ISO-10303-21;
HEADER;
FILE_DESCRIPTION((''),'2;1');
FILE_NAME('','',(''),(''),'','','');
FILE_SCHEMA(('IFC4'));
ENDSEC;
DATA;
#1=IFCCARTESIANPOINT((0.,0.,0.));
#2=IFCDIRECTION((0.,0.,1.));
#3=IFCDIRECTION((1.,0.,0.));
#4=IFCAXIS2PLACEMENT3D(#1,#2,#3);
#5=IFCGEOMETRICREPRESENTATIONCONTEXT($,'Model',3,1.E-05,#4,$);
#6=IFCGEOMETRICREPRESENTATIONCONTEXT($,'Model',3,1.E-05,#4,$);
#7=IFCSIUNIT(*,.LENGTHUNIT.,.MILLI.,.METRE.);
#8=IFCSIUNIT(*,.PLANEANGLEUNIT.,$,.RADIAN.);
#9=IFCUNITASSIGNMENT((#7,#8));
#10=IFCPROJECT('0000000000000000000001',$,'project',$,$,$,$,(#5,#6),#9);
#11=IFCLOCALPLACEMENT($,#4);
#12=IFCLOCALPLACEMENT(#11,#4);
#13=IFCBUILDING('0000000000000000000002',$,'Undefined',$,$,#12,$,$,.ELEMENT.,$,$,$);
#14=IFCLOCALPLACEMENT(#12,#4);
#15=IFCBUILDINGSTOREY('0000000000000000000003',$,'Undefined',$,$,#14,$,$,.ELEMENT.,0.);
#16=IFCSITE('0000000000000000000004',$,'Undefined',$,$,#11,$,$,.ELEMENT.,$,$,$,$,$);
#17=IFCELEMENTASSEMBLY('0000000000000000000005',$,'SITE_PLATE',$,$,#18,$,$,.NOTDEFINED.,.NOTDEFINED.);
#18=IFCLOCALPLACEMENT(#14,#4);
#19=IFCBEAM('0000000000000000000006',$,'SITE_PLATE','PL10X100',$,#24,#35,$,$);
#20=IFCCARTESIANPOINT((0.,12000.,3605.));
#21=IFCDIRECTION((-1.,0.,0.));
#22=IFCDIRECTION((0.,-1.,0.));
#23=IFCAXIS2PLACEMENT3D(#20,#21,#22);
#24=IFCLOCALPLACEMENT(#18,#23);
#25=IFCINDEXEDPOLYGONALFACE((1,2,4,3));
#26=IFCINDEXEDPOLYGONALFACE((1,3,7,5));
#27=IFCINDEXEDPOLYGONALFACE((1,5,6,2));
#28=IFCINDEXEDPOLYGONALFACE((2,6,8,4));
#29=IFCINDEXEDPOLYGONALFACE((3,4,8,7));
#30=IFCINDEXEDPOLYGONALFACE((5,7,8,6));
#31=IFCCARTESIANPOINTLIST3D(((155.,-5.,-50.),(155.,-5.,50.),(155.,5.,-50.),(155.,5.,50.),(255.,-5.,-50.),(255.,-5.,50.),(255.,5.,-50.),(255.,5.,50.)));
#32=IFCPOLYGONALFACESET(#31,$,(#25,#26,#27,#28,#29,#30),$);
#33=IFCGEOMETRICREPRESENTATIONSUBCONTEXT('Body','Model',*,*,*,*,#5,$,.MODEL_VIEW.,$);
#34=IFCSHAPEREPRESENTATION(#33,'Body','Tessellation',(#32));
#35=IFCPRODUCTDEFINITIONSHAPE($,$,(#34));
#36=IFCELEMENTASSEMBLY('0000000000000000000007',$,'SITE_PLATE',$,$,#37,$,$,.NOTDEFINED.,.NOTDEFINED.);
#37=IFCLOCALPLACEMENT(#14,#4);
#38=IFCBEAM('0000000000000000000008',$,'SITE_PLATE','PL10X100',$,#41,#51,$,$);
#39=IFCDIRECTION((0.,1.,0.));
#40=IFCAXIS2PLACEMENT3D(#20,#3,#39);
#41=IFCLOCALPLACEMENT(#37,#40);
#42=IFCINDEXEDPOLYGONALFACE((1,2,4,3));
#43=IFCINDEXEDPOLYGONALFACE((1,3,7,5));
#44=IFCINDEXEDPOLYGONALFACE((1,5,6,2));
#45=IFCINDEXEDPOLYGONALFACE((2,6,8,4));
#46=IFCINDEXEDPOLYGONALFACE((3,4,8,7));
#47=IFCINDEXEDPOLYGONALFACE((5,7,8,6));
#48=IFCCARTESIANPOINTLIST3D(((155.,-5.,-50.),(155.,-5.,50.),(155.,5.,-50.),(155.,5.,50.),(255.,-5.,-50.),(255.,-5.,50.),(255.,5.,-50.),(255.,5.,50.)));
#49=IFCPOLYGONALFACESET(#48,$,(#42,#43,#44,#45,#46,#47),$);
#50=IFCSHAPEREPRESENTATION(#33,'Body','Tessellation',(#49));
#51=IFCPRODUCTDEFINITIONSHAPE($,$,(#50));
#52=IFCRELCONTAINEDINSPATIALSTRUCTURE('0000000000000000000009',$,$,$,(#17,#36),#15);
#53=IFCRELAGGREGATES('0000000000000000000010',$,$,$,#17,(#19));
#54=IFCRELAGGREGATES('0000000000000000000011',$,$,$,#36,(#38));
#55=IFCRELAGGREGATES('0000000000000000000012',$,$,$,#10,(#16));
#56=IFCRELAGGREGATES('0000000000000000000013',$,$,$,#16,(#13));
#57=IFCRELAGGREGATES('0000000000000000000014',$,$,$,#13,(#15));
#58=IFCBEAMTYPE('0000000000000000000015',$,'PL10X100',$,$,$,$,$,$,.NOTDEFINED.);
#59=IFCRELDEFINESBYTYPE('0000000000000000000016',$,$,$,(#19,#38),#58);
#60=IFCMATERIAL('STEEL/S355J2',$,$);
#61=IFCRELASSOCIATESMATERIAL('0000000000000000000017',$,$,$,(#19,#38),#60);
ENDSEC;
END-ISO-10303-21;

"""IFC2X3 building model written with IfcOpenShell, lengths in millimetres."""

from ifc_helpers import new_model, si_unit, frame, origin_with_axes, origin_2d_with_axis, place, context, subcontext, project, spatial, rectangle, extrude, clip, halfspace, material, type_object, element, aggregate, save


model = new_model("IFC2X3")

# Units and contexts
model_context_1 = context("Model", 3, precision=1e-05, world=origin_with_axes())
model_context_2 = context("Model", 3, precision=1e-05, world=origin_with_axes())
body_context = subcontext(model_context_1, "Body", "Model", "MODEL_VIEW")
ifc_project = project(units=[si_unit("LENGTHUNIT", "METRE", prefix="MILLI"), si_unit("PLANEANGLEUNIT", "RADIAN")], contexts=[model_context_1, model_context_2])

# Site, building, storey
site_placement = place(None, origin_with_axes())
site = spatial("IfcSite", under=ifc_project, at=site_placement, Name="Undefined", CompositionType="ELEMENT")
building_placement = place(site_placement, origin_with_axes())
building = spatial("IfcBuilding", under=site, at=building_placement, Name="Undefined", CompositionType="ELEMENT")
storey_placement = place(building_placement, origin_with_axes())
storey = spatial("IfcBuildingStorey", under=building, at=storey_placement, Name="Undefined", CompositionType="ELEMENT", Elevation=0.0)

# Element assemblies, beams
ifc_material_1 = material(Name="STEEL/S355J2")
assembly_1_placement = place(storey_placement, origin_with_axes())
assembly_1 = element("IfcElementAssembly", 1, at=assembly_1_placement, inside=storey, Name="SITE_PLATE", AssemblyPlace="NOTDEFINED", PredefinedType="NOTDEFINED")
beam_type_1 = type_object("IfcBeamType", Name="PL10X100", PredefinedType="NOTDEFINED")
beam_1_placement = place(assembly_1_placement, frame((0.0, 12000.0, 3605.0), z_axis=(-1.0, 0.0, 0.0), x_axis=(0.0, -1.0, 0.0)))
beam_1 = element("IfcBeam", 2, at=beam_1_placement, type_object=beam_type_1, material=ifc_material_1, Name="SITE_PLATE", Description="PL10X100", context=body_context, shape_type="Clipping", body=[
    clip(extrude(rectangle(XDim=10.0, YDim=100.0, at=origin_2d_with_axis()), frame((255.0, 0.0, 0.0), z_axis=(-1.0, 0.0, 0.0), x_axis=(0.0, -1.0, 0.0)), (0.0, 0.0, 1.0), 255.0), halfspace(frame((155.0, 5.0, -50.0), z_axis=(-1.0, 0.0, 0.0), x_axis=(0.0, 0.0, 1.0)), False)),
])
aggregate(assembly_1, [beam_1])
assembly_2_placement = place(storey_placement, origin_with_axes())
assembly_2 = element("IfcElementAssembly", 3, at=assembly_2_placement, inside=storey, Name="SITE_PLATE", AssemblyPlace="NOTDEFINED", PredefinedType="NOTDEFINED")
beam_2_placement = place(assembly_2_placement, frame((0.0, 12000.0, 3605.0), z_axis=(1.0, 0.0, 0.0), x_axis=(0.0, 1.0, 0.0)))
beam_2 = element("IfcBeam", 4, at=beam_2_placement, type_object=beam_type_1, material=ifc_material_1, Name="SITE_PLATE", Description="PL10X100", context=body_context, shape_type="Clipping", body=[
    clip(extrude(rectangle(XDim=10.0, YDim=100.0, at=origin_2d_with_axis()), frame((255.0, 0.0, 0.0), z_axis=(-1.0, 0.0, 0.0), x_axis=(0.0, -1.0, 0.0)), (0.0, 0.0, 1.0), 255.0), halfspace(frame((155.0, 5.0, -50.0), z_axis=(-1.0, 0.0, 0.0), x_axis=(0.0, 0.0, 1.0)), False)),
])
aggregate(assembly_2, [beam_2])

save(model, "model.ifc")
